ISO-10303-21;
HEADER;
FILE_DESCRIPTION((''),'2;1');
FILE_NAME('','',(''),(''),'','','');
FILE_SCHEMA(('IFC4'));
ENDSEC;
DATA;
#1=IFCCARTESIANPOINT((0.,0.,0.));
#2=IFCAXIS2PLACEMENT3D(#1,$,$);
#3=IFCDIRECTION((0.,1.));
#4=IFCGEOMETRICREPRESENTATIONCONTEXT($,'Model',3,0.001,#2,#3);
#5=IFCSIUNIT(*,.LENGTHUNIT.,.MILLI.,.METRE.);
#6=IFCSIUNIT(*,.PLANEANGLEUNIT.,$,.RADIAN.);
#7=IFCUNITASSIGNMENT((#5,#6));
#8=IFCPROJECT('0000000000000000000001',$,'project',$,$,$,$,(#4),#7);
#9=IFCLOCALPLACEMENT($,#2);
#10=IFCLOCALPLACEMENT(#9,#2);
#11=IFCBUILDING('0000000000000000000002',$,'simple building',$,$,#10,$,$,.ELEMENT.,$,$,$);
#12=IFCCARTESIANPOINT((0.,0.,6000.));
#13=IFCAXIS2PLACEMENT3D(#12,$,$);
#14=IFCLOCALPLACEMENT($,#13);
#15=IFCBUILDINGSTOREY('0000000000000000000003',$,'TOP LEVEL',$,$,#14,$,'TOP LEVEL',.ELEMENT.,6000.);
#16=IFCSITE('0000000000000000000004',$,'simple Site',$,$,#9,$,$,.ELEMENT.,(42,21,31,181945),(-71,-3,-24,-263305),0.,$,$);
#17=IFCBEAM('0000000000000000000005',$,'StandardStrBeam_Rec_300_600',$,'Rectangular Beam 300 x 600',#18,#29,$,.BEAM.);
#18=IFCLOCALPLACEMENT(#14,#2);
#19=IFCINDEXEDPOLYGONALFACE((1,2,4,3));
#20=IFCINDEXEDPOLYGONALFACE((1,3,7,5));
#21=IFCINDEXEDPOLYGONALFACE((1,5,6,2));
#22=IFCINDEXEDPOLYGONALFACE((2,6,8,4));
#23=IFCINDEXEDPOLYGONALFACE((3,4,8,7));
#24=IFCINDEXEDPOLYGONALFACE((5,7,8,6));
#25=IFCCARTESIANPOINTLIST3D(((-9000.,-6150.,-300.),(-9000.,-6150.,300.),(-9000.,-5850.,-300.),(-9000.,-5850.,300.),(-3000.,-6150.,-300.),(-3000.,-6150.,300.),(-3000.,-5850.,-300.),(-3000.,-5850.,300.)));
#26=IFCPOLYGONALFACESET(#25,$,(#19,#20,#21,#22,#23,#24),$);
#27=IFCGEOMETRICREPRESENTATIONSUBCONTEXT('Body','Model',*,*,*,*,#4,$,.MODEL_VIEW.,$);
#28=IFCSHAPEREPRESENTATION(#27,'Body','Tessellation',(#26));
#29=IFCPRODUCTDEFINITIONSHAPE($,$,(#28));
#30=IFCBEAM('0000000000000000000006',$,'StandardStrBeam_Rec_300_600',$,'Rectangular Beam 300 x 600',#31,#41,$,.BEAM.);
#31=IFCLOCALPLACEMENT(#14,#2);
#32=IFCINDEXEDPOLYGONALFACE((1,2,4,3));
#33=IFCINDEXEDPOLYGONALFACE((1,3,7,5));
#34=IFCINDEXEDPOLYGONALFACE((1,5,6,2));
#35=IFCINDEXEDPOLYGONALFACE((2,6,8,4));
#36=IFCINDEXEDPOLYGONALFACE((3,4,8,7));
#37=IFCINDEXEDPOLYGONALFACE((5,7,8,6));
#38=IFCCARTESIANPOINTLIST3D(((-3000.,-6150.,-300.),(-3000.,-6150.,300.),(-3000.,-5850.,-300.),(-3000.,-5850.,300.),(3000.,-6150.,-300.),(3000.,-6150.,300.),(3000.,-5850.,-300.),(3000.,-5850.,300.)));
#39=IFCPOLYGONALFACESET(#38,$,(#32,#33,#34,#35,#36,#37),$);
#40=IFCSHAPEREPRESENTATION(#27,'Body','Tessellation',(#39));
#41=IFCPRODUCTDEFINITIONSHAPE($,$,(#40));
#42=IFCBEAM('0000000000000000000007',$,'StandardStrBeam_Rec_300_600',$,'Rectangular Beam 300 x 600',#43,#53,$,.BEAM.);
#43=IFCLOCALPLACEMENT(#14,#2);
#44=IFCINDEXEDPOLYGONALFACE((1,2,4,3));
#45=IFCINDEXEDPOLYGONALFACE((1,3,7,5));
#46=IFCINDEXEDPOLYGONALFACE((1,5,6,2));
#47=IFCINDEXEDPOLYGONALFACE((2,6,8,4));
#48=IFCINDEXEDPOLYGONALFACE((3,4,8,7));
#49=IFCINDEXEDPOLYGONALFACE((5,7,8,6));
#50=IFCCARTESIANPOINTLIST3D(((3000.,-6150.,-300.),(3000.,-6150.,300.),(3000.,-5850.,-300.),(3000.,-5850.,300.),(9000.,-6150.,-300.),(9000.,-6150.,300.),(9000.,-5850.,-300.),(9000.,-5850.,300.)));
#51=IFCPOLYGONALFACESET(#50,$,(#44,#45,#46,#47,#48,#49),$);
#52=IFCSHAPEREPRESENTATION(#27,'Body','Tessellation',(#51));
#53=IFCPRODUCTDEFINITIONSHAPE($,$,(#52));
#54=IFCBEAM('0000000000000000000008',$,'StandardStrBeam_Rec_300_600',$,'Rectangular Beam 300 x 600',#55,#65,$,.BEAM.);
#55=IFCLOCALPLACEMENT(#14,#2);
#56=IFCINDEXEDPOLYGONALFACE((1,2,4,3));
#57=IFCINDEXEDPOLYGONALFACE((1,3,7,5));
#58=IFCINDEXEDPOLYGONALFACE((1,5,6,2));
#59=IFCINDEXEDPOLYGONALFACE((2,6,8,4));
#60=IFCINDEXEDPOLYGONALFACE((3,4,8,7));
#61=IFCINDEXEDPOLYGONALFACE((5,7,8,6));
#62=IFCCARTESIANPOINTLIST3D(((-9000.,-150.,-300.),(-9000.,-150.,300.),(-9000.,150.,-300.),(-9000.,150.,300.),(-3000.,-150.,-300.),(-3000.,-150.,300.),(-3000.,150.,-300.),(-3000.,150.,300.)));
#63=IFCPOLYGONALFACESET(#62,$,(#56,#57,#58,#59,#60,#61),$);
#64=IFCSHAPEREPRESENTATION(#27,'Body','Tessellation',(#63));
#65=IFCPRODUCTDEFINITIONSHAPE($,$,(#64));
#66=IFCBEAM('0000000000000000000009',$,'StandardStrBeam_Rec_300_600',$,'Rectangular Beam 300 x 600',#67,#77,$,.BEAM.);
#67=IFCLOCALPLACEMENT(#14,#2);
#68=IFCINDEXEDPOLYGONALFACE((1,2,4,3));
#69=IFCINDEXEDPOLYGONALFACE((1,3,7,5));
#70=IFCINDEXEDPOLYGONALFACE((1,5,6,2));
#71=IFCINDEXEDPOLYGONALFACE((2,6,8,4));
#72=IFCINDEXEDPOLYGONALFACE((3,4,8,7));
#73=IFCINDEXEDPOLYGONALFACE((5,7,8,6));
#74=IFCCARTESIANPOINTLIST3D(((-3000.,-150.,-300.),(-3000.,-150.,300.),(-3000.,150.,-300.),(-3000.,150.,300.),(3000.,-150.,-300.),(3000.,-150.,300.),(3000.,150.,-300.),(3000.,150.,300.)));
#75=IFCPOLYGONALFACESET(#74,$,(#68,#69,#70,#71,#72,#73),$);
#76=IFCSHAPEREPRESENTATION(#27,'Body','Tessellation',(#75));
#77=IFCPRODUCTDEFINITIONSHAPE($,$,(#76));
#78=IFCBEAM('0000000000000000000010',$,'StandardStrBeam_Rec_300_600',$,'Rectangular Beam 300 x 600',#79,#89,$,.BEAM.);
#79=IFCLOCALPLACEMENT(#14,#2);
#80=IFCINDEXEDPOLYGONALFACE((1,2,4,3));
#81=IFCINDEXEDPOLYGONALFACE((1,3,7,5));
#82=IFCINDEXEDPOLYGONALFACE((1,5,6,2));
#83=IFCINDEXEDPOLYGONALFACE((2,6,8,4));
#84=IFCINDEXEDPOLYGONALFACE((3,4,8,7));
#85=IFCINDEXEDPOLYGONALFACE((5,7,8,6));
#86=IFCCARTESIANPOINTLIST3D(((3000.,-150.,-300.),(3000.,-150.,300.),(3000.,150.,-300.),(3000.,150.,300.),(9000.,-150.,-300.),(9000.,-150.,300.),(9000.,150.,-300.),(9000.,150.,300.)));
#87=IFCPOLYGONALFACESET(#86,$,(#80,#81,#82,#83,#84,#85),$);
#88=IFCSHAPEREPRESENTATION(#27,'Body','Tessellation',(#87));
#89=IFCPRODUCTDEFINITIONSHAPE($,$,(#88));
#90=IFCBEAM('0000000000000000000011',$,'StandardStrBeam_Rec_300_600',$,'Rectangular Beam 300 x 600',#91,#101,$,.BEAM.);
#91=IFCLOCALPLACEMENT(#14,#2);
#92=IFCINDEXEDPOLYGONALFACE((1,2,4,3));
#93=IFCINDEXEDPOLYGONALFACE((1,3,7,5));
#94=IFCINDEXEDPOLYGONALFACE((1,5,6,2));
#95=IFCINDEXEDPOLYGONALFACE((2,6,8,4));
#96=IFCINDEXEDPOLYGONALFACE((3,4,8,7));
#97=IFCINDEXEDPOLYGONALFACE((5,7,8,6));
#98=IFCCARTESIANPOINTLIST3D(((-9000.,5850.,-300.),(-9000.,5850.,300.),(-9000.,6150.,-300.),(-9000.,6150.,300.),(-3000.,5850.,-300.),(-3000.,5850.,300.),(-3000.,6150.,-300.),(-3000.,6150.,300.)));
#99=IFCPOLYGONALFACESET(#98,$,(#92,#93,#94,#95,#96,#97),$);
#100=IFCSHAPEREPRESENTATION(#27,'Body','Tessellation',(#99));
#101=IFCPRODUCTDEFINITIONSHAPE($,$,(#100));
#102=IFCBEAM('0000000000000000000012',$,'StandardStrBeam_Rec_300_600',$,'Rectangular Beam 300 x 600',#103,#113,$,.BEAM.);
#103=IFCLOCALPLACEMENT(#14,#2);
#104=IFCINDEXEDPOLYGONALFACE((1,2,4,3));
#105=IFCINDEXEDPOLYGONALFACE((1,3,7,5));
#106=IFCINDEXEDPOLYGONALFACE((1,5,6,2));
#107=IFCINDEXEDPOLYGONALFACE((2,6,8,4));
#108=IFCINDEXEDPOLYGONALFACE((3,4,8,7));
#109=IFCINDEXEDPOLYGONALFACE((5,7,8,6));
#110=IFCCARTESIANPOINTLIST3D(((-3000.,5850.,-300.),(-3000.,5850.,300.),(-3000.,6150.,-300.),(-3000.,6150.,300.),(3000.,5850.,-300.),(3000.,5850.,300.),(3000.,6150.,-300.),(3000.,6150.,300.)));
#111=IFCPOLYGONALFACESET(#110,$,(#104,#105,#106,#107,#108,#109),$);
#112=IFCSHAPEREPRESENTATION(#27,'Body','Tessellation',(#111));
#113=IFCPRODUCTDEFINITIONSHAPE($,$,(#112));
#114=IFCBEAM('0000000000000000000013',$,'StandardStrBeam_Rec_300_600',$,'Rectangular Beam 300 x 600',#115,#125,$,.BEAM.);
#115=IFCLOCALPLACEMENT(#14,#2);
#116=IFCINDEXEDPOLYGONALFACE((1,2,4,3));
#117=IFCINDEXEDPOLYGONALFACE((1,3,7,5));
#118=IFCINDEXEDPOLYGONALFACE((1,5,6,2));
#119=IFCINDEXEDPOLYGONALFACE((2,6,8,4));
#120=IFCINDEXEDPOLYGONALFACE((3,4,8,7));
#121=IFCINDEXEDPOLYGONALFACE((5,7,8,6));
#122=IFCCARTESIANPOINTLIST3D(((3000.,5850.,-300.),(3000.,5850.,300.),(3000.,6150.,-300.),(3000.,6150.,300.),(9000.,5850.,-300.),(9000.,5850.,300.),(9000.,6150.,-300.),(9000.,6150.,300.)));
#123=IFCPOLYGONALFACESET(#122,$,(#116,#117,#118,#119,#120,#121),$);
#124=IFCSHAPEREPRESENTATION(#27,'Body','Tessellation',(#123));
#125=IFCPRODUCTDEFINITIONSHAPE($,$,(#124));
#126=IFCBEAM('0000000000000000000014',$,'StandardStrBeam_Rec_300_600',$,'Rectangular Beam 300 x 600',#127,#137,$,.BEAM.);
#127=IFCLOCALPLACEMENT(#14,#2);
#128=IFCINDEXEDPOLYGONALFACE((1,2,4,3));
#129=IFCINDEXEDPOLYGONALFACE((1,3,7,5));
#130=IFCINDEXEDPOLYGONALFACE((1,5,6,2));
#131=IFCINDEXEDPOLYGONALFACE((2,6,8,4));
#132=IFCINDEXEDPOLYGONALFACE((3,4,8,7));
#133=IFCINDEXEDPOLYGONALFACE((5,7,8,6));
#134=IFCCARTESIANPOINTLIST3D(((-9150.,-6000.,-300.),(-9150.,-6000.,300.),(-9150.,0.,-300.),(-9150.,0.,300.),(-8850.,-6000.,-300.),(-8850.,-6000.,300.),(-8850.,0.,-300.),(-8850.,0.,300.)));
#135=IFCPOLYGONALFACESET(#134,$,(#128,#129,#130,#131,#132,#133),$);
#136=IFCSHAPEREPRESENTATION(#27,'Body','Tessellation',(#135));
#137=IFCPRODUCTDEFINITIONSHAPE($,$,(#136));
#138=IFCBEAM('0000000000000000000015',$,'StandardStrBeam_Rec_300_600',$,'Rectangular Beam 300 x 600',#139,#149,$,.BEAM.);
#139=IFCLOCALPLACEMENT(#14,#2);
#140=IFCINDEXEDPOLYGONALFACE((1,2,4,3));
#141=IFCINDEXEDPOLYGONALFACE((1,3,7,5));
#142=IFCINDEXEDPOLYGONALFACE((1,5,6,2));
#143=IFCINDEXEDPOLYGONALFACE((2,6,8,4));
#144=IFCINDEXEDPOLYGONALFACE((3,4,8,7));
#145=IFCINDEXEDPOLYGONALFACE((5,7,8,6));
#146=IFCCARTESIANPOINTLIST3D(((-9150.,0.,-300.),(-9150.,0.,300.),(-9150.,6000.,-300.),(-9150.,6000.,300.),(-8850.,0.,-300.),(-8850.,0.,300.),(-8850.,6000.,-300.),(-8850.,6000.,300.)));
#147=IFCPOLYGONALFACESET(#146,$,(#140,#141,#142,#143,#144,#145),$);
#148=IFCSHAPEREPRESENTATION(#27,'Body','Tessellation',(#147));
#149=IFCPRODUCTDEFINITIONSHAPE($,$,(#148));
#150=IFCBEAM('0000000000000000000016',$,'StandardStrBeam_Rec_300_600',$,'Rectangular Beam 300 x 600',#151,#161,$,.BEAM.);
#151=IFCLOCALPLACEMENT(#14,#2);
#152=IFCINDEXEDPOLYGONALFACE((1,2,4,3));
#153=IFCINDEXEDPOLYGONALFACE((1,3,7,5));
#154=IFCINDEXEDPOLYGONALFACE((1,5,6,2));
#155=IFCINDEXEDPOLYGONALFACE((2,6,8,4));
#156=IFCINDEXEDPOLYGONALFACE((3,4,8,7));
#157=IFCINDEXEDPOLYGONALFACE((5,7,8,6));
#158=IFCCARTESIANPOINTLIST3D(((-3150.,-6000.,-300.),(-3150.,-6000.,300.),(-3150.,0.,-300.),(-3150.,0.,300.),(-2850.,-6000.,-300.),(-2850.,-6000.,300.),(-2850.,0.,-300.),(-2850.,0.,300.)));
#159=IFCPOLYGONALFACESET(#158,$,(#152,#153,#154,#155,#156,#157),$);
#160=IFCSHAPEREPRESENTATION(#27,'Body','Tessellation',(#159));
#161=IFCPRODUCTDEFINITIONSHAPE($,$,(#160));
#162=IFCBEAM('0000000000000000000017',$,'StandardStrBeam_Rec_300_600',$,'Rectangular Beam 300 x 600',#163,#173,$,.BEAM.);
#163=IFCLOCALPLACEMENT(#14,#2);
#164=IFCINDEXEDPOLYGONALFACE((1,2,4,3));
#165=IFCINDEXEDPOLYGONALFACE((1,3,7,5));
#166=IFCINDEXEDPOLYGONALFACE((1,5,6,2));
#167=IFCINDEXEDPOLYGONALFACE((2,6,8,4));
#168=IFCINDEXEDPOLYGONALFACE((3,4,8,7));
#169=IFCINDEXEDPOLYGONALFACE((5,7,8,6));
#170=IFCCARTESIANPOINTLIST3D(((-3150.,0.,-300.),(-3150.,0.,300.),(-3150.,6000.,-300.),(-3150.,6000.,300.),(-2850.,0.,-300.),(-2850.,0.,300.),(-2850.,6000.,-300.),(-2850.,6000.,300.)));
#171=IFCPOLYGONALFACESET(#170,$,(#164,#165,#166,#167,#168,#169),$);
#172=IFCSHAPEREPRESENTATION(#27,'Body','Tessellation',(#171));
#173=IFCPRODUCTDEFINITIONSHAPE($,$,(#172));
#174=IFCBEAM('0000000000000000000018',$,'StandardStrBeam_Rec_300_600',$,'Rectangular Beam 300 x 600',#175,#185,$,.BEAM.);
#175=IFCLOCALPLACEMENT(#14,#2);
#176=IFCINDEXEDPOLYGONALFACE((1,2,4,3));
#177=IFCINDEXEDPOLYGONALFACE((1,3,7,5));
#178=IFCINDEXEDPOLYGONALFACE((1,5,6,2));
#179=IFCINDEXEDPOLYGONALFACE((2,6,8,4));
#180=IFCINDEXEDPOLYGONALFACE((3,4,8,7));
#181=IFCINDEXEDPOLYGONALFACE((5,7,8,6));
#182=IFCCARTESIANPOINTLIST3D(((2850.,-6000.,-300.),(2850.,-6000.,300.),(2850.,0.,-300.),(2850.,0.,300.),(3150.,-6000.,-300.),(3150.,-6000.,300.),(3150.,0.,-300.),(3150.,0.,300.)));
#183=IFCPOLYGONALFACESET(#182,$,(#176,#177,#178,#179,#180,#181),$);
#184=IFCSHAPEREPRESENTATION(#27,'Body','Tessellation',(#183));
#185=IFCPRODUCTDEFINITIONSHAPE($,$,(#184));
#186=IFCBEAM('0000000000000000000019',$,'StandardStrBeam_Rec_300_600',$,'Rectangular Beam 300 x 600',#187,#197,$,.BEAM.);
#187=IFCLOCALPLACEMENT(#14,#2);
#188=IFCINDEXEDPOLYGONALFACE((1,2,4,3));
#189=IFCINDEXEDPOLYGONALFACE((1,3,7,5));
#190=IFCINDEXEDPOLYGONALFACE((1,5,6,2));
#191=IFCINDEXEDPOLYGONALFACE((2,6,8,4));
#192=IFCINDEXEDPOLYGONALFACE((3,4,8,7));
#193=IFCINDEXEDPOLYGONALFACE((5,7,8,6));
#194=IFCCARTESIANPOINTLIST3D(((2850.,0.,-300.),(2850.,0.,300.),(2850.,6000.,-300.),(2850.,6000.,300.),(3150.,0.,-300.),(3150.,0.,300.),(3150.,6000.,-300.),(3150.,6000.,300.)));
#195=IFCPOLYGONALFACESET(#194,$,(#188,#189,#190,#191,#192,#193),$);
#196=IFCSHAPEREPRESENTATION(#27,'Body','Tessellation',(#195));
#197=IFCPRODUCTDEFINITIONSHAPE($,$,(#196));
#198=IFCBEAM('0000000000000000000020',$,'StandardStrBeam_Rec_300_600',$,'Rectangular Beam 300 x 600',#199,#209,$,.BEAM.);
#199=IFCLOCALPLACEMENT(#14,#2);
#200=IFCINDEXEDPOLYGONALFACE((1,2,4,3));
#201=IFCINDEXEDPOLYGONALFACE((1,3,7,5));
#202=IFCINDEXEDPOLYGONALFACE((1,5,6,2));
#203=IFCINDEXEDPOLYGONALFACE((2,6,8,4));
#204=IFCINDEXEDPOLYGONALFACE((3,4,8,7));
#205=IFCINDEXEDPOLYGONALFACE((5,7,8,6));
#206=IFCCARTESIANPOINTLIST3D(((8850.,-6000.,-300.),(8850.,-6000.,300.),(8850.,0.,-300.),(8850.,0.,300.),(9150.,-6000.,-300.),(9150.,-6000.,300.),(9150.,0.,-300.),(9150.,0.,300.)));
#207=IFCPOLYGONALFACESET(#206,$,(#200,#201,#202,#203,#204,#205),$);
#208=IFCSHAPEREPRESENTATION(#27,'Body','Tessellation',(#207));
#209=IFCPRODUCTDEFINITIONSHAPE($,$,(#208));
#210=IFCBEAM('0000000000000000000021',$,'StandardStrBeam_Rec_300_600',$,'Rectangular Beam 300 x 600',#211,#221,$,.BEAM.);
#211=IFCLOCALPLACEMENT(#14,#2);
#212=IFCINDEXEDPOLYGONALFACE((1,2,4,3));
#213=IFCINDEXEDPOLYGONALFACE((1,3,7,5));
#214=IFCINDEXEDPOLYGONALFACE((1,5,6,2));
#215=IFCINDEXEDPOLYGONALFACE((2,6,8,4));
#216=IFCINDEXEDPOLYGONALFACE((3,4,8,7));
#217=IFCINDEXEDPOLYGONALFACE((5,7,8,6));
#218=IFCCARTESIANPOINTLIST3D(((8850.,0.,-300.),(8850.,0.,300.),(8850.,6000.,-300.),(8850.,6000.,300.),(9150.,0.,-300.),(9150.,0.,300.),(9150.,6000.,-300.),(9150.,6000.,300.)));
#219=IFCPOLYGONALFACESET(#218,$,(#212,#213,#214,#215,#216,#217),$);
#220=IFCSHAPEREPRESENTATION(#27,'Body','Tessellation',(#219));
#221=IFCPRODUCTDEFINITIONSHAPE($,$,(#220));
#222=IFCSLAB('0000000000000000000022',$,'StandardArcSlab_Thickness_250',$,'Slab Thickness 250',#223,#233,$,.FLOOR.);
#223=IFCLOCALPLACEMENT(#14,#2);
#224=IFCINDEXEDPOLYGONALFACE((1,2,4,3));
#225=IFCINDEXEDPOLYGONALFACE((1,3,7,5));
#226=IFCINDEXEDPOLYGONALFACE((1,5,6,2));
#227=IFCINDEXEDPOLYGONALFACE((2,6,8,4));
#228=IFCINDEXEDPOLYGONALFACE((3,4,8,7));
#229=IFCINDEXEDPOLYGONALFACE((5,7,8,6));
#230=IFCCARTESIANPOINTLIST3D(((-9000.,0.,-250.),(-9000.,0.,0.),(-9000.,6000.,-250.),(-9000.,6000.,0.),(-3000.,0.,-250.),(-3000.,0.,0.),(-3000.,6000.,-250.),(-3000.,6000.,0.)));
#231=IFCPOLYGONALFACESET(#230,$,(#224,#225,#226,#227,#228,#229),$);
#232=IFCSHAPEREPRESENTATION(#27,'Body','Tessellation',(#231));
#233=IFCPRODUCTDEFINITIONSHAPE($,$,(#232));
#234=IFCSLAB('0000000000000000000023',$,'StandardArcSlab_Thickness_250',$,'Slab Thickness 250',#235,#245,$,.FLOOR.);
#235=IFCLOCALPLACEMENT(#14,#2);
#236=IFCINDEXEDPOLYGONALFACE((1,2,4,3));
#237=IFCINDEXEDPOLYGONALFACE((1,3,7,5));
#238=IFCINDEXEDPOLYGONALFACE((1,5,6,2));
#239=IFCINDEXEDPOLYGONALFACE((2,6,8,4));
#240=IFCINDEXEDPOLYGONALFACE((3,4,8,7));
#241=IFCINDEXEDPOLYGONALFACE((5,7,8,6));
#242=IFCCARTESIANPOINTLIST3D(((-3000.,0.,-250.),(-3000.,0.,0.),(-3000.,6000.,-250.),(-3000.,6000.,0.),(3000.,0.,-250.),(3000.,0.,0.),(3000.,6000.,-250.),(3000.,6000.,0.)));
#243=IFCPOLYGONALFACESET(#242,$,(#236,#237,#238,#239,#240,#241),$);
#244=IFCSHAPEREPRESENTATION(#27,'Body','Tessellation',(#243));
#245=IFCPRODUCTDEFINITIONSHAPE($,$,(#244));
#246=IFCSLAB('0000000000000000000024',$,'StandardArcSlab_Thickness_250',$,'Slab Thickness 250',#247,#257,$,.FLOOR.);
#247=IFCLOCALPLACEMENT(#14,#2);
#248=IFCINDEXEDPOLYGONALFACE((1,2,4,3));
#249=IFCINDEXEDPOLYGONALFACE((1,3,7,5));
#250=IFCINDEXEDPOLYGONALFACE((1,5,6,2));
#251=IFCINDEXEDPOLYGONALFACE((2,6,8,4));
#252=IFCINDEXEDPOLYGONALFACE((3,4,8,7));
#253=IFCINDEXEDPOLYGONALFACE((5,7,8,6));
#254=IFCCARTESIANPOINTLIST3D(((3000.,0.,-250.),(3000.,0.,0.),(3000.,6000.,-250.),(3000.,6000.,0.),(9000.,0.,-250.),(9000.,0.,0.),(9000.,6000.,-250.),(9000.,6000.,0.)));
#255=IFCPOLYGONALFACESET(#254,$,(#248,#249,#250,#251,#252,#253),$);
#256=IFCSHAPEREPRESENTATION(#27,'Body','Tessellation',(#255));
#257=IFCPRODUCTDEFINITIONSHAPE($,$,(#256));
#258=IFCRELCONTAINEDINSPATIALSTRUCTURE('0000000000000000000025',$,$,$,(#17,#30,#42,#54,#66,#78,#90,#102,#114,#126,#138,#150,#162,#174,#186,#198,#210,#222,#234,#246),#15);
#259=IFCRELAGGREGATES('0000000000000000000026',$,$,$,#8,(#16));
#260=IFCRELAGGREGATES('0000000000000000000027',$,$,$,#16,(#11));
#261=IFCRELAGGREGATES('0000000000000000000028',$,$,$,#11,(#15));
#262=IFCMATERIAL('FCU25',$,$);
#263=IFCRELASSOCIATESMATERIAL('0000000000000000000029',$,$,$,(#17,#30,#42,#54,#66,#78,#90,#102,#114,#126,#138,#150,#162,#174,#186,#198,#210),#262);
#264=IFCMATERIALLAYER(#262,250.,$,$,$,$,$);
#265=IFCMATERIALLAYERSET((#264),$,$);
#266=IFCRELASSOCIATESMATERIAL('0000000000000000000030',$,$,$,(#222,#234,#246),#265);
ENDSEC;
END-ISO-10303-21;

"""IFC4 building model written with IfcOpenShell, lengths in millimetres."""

from ifc_helpers import new_model, si_unit, direction, frame, origin, origin_with_axes, origin_2d_with_axis, place, context, subcontext, project, spatial, polyline, rectangle, outline, extrude, material, layer, layer_set, layer_usage, material_profile, profile_set, profile_usage, element, save


model = new_model("IFC4")

# Units and contexts
model_context = context("Model", 3, precision=0.001, world=origin(), true_north=direction((0.0, 1.0)))
body_context = subcontext(model_context, "Body", "Model", "MODEL_VIEW")
ifc_project = project(units=[si_unit("LENGTHUNIT", "METRE", prefix="MILLI"), si_unit("PLANEANGLEUNIT", "RADIAN")], contexts=[model_context])

# Site, building, storey
site_placement = place(None, origin())
site = spatial("IfcSite", under=ifc_project, at=site_placement, Name="simple Site", CompositionType="ELEMENT", RefLatitude=(42, 21, 31, 181945), RefLongitude=(-71, -3, -24, -263305), RefElevation=0.0)
building_placement = place(site_placement, origin())
building = spatial("IfcBuilding", under=site, at=building_placement, Name="simple building", CompositionType="ELEMENT")
storey_placement = place(None, frame((0.0, 0.0, 6000.0)))
storey = spatial("IfcBuildingStorey", under=building, at=storey_placement, Name="TOP LEVEL", LongName="TOP LEVEL", CompositionType="ELEMENT", Elevation=6000.0)

# Beams
ifc_material = material(Name="FCU25")
ifc_material_profile = material_profile(ifc_material, rectangle(XDim=300.0, YDim=600.0, at=origin_2d_with_axis()))
ifc_profile_set = profile_set([ifc_material_profile])
ifc_profile_usage = profile_usage(ifc_profile_set, cardinal=10)
for number, where, z_axis, x_axis, name in (
    (1, (-9000.0, -6000.0, 6000.0), (1.0, 0.0, 0.0), (0.0, -1.0, 0.0), "StandardStrBeam_Rec_300_600"),
    (2, (-3000.0, -6000.0, 6000.0), (1.0, 0.0, 0.0), (0.0, -1.0, 0.0), "StandardStrBeam_Rec_300_600"),
    (3, (3000.0, -6000.0, 6000.0), (1.0, 0.0, 0.0), (0.0, -1.0, 0.0), "StandardStrBeam_Rec_300_600"),
    (4, (-9000.0, 0.0, 6000.0), (1.0, 0.0, 0.0), (0.0, -1.0, 0.0), "StandardStrBeam_Rec_300_600"),
    (5, (-3000.0, 0.0, 6000.0), (1.0, 0.0, 0.0), (0.0, -1.0, 0.0), "StandardStrBeam_Rec_300_600"),
    (6, (3000.0, 0.0, 6000.0), (1.0, 0.0, 0.0), (0.0, -1.0, 0.0), "StandardStrBeam_Rec_300_600"),
    (7, (-9000.0, 6000.0, 6000.0), (1.0, 0.0, 0.0), (0.0, -1.0, 0.0), "StandardStrBeam_Rec_300_600"),
    (8, (-3000.0, 6000.0, 6000.0), (1.0, 0.0, 0.0), (0.0, -1.0, 0.0), "StandardStrBeam_Rec_300_600"),
    (9, (3000.0, 6000.0, 6000.0), (1.0, 0.0, 0.0), (0.0, -1.0, 0.0), "StandardStrBeam_Rec_300_600"),
    (10, (-9000.0, -6000.0, 6000.0), (0.0, 1.0, 0.0), (1.0, 0.0, 0.0), "StandardStrBeam_Rec_300_600"),
    (11, (-9000.0, 0.0, 6000.0), (0.0, 1.0, 0.0), (1.0, 0.0, 0.0), "StandardStrBeam_Rec_300_600"),
    (12, (-3000.0, -6000.0, 6000.0), (0.0, 1.0, 0.0), (1.0, 0.0, 0.0), "StandardStrBeam_Rec_300_600"),
    (13, (-3000.0, 0.0, 6000.0), (0.0, 1.0, 0.0), (1.0, 0.0, 0.0), "StandardStrBeam_Rec_300_600"),
    (14, (3000.0, -6000.0, 6000.0), (0.0, 1.0, 0.0), (1.0, 0.0, 0.0), "StandardStrBeam_Rec_300_600"),
    (15, (3000.0, 0.0, 6000.0), (0.0, 1.0, 0.0), (1.0, 0.0, 0.0), "StandardStrBeam_Rec_300_600"),
    (16, (9000.0, -6000.0, 6000.0), (0.0, 1.0, 0.0), (1.0, 0.0, 0.0), "StandardStrBeam_Rec_300_600"),
    (17, (9000.0, 0.0, 6000.0), (0.0, 1.0, 0.0), (1.0, 0.0, 0.0), "StandardStrBeam_Rec_300_600"),
):
    element("IfcBeam", number, at=place(None, frame(where, z_axis=z_axis, x_axis=x_axis)), inside=storey, material=ifc_profile_usage, Name=name, ObjectType="Rectangular Beam 300 x 600", PredefinedType="BEAM", context=body_context, shape_type="SweptSolid", body=[
        extrude(rectangle(XDim=300.0, YDim=600.0, at=origin_2d_with_axis()), origin_with_axes(), (0.0, 0.0, 1.0), 6000.0),
    ])

# Slabs
ifc_layer = layer(ifc_material, 250.0)
ifc_layer_set = layer_set([ifc_layer])
ifc_layer_usage = layer_usage(ifc_layer_set, "AXIS3", "POSITIVE", -250.0)
for number, where, z_axis, x_axis, name in (
    (18, (-9000.0, 0.0, 5750.0), (0.0, 0.0, 1.0), (1.0, 0.0, 0.0), "StandardArcSlab_Thickness_250"),
    (19, (-3000.0, 0.0, 5750.0), (0.0, 0.0, 1.0), (1.0, 0.0, 0.0), "StandardArcSlab_Thickness_250"),
    (20, (3000.0, 0.0, 5750.0), (0.0, 0.0, 1.0), (1.0, 0.0, 0.0), "StandardArcSlab_Thickness_250"),
):
    element("IfcSlab", number, at=place(None, frame(where, z_axis=z_axis, x_axis=x_axis)), inside=storey, material=ifc_layer_usage, Name=name, ObjectType="Slab Thickness 250", PredefinedType="FLOOR", context=body_context, shape_type="SweptSolid", body=[
        extrude(outline(polyline([(0.0, 0.0), (6000.0, 0.0), (6000.0, 6000.0), (0.0, 6000.0), (0.0, 0.0)])), origin_with_axes(), (0.0, 0.0, 1.0), 250.0),
    ])

save(model, "model.ifc")
